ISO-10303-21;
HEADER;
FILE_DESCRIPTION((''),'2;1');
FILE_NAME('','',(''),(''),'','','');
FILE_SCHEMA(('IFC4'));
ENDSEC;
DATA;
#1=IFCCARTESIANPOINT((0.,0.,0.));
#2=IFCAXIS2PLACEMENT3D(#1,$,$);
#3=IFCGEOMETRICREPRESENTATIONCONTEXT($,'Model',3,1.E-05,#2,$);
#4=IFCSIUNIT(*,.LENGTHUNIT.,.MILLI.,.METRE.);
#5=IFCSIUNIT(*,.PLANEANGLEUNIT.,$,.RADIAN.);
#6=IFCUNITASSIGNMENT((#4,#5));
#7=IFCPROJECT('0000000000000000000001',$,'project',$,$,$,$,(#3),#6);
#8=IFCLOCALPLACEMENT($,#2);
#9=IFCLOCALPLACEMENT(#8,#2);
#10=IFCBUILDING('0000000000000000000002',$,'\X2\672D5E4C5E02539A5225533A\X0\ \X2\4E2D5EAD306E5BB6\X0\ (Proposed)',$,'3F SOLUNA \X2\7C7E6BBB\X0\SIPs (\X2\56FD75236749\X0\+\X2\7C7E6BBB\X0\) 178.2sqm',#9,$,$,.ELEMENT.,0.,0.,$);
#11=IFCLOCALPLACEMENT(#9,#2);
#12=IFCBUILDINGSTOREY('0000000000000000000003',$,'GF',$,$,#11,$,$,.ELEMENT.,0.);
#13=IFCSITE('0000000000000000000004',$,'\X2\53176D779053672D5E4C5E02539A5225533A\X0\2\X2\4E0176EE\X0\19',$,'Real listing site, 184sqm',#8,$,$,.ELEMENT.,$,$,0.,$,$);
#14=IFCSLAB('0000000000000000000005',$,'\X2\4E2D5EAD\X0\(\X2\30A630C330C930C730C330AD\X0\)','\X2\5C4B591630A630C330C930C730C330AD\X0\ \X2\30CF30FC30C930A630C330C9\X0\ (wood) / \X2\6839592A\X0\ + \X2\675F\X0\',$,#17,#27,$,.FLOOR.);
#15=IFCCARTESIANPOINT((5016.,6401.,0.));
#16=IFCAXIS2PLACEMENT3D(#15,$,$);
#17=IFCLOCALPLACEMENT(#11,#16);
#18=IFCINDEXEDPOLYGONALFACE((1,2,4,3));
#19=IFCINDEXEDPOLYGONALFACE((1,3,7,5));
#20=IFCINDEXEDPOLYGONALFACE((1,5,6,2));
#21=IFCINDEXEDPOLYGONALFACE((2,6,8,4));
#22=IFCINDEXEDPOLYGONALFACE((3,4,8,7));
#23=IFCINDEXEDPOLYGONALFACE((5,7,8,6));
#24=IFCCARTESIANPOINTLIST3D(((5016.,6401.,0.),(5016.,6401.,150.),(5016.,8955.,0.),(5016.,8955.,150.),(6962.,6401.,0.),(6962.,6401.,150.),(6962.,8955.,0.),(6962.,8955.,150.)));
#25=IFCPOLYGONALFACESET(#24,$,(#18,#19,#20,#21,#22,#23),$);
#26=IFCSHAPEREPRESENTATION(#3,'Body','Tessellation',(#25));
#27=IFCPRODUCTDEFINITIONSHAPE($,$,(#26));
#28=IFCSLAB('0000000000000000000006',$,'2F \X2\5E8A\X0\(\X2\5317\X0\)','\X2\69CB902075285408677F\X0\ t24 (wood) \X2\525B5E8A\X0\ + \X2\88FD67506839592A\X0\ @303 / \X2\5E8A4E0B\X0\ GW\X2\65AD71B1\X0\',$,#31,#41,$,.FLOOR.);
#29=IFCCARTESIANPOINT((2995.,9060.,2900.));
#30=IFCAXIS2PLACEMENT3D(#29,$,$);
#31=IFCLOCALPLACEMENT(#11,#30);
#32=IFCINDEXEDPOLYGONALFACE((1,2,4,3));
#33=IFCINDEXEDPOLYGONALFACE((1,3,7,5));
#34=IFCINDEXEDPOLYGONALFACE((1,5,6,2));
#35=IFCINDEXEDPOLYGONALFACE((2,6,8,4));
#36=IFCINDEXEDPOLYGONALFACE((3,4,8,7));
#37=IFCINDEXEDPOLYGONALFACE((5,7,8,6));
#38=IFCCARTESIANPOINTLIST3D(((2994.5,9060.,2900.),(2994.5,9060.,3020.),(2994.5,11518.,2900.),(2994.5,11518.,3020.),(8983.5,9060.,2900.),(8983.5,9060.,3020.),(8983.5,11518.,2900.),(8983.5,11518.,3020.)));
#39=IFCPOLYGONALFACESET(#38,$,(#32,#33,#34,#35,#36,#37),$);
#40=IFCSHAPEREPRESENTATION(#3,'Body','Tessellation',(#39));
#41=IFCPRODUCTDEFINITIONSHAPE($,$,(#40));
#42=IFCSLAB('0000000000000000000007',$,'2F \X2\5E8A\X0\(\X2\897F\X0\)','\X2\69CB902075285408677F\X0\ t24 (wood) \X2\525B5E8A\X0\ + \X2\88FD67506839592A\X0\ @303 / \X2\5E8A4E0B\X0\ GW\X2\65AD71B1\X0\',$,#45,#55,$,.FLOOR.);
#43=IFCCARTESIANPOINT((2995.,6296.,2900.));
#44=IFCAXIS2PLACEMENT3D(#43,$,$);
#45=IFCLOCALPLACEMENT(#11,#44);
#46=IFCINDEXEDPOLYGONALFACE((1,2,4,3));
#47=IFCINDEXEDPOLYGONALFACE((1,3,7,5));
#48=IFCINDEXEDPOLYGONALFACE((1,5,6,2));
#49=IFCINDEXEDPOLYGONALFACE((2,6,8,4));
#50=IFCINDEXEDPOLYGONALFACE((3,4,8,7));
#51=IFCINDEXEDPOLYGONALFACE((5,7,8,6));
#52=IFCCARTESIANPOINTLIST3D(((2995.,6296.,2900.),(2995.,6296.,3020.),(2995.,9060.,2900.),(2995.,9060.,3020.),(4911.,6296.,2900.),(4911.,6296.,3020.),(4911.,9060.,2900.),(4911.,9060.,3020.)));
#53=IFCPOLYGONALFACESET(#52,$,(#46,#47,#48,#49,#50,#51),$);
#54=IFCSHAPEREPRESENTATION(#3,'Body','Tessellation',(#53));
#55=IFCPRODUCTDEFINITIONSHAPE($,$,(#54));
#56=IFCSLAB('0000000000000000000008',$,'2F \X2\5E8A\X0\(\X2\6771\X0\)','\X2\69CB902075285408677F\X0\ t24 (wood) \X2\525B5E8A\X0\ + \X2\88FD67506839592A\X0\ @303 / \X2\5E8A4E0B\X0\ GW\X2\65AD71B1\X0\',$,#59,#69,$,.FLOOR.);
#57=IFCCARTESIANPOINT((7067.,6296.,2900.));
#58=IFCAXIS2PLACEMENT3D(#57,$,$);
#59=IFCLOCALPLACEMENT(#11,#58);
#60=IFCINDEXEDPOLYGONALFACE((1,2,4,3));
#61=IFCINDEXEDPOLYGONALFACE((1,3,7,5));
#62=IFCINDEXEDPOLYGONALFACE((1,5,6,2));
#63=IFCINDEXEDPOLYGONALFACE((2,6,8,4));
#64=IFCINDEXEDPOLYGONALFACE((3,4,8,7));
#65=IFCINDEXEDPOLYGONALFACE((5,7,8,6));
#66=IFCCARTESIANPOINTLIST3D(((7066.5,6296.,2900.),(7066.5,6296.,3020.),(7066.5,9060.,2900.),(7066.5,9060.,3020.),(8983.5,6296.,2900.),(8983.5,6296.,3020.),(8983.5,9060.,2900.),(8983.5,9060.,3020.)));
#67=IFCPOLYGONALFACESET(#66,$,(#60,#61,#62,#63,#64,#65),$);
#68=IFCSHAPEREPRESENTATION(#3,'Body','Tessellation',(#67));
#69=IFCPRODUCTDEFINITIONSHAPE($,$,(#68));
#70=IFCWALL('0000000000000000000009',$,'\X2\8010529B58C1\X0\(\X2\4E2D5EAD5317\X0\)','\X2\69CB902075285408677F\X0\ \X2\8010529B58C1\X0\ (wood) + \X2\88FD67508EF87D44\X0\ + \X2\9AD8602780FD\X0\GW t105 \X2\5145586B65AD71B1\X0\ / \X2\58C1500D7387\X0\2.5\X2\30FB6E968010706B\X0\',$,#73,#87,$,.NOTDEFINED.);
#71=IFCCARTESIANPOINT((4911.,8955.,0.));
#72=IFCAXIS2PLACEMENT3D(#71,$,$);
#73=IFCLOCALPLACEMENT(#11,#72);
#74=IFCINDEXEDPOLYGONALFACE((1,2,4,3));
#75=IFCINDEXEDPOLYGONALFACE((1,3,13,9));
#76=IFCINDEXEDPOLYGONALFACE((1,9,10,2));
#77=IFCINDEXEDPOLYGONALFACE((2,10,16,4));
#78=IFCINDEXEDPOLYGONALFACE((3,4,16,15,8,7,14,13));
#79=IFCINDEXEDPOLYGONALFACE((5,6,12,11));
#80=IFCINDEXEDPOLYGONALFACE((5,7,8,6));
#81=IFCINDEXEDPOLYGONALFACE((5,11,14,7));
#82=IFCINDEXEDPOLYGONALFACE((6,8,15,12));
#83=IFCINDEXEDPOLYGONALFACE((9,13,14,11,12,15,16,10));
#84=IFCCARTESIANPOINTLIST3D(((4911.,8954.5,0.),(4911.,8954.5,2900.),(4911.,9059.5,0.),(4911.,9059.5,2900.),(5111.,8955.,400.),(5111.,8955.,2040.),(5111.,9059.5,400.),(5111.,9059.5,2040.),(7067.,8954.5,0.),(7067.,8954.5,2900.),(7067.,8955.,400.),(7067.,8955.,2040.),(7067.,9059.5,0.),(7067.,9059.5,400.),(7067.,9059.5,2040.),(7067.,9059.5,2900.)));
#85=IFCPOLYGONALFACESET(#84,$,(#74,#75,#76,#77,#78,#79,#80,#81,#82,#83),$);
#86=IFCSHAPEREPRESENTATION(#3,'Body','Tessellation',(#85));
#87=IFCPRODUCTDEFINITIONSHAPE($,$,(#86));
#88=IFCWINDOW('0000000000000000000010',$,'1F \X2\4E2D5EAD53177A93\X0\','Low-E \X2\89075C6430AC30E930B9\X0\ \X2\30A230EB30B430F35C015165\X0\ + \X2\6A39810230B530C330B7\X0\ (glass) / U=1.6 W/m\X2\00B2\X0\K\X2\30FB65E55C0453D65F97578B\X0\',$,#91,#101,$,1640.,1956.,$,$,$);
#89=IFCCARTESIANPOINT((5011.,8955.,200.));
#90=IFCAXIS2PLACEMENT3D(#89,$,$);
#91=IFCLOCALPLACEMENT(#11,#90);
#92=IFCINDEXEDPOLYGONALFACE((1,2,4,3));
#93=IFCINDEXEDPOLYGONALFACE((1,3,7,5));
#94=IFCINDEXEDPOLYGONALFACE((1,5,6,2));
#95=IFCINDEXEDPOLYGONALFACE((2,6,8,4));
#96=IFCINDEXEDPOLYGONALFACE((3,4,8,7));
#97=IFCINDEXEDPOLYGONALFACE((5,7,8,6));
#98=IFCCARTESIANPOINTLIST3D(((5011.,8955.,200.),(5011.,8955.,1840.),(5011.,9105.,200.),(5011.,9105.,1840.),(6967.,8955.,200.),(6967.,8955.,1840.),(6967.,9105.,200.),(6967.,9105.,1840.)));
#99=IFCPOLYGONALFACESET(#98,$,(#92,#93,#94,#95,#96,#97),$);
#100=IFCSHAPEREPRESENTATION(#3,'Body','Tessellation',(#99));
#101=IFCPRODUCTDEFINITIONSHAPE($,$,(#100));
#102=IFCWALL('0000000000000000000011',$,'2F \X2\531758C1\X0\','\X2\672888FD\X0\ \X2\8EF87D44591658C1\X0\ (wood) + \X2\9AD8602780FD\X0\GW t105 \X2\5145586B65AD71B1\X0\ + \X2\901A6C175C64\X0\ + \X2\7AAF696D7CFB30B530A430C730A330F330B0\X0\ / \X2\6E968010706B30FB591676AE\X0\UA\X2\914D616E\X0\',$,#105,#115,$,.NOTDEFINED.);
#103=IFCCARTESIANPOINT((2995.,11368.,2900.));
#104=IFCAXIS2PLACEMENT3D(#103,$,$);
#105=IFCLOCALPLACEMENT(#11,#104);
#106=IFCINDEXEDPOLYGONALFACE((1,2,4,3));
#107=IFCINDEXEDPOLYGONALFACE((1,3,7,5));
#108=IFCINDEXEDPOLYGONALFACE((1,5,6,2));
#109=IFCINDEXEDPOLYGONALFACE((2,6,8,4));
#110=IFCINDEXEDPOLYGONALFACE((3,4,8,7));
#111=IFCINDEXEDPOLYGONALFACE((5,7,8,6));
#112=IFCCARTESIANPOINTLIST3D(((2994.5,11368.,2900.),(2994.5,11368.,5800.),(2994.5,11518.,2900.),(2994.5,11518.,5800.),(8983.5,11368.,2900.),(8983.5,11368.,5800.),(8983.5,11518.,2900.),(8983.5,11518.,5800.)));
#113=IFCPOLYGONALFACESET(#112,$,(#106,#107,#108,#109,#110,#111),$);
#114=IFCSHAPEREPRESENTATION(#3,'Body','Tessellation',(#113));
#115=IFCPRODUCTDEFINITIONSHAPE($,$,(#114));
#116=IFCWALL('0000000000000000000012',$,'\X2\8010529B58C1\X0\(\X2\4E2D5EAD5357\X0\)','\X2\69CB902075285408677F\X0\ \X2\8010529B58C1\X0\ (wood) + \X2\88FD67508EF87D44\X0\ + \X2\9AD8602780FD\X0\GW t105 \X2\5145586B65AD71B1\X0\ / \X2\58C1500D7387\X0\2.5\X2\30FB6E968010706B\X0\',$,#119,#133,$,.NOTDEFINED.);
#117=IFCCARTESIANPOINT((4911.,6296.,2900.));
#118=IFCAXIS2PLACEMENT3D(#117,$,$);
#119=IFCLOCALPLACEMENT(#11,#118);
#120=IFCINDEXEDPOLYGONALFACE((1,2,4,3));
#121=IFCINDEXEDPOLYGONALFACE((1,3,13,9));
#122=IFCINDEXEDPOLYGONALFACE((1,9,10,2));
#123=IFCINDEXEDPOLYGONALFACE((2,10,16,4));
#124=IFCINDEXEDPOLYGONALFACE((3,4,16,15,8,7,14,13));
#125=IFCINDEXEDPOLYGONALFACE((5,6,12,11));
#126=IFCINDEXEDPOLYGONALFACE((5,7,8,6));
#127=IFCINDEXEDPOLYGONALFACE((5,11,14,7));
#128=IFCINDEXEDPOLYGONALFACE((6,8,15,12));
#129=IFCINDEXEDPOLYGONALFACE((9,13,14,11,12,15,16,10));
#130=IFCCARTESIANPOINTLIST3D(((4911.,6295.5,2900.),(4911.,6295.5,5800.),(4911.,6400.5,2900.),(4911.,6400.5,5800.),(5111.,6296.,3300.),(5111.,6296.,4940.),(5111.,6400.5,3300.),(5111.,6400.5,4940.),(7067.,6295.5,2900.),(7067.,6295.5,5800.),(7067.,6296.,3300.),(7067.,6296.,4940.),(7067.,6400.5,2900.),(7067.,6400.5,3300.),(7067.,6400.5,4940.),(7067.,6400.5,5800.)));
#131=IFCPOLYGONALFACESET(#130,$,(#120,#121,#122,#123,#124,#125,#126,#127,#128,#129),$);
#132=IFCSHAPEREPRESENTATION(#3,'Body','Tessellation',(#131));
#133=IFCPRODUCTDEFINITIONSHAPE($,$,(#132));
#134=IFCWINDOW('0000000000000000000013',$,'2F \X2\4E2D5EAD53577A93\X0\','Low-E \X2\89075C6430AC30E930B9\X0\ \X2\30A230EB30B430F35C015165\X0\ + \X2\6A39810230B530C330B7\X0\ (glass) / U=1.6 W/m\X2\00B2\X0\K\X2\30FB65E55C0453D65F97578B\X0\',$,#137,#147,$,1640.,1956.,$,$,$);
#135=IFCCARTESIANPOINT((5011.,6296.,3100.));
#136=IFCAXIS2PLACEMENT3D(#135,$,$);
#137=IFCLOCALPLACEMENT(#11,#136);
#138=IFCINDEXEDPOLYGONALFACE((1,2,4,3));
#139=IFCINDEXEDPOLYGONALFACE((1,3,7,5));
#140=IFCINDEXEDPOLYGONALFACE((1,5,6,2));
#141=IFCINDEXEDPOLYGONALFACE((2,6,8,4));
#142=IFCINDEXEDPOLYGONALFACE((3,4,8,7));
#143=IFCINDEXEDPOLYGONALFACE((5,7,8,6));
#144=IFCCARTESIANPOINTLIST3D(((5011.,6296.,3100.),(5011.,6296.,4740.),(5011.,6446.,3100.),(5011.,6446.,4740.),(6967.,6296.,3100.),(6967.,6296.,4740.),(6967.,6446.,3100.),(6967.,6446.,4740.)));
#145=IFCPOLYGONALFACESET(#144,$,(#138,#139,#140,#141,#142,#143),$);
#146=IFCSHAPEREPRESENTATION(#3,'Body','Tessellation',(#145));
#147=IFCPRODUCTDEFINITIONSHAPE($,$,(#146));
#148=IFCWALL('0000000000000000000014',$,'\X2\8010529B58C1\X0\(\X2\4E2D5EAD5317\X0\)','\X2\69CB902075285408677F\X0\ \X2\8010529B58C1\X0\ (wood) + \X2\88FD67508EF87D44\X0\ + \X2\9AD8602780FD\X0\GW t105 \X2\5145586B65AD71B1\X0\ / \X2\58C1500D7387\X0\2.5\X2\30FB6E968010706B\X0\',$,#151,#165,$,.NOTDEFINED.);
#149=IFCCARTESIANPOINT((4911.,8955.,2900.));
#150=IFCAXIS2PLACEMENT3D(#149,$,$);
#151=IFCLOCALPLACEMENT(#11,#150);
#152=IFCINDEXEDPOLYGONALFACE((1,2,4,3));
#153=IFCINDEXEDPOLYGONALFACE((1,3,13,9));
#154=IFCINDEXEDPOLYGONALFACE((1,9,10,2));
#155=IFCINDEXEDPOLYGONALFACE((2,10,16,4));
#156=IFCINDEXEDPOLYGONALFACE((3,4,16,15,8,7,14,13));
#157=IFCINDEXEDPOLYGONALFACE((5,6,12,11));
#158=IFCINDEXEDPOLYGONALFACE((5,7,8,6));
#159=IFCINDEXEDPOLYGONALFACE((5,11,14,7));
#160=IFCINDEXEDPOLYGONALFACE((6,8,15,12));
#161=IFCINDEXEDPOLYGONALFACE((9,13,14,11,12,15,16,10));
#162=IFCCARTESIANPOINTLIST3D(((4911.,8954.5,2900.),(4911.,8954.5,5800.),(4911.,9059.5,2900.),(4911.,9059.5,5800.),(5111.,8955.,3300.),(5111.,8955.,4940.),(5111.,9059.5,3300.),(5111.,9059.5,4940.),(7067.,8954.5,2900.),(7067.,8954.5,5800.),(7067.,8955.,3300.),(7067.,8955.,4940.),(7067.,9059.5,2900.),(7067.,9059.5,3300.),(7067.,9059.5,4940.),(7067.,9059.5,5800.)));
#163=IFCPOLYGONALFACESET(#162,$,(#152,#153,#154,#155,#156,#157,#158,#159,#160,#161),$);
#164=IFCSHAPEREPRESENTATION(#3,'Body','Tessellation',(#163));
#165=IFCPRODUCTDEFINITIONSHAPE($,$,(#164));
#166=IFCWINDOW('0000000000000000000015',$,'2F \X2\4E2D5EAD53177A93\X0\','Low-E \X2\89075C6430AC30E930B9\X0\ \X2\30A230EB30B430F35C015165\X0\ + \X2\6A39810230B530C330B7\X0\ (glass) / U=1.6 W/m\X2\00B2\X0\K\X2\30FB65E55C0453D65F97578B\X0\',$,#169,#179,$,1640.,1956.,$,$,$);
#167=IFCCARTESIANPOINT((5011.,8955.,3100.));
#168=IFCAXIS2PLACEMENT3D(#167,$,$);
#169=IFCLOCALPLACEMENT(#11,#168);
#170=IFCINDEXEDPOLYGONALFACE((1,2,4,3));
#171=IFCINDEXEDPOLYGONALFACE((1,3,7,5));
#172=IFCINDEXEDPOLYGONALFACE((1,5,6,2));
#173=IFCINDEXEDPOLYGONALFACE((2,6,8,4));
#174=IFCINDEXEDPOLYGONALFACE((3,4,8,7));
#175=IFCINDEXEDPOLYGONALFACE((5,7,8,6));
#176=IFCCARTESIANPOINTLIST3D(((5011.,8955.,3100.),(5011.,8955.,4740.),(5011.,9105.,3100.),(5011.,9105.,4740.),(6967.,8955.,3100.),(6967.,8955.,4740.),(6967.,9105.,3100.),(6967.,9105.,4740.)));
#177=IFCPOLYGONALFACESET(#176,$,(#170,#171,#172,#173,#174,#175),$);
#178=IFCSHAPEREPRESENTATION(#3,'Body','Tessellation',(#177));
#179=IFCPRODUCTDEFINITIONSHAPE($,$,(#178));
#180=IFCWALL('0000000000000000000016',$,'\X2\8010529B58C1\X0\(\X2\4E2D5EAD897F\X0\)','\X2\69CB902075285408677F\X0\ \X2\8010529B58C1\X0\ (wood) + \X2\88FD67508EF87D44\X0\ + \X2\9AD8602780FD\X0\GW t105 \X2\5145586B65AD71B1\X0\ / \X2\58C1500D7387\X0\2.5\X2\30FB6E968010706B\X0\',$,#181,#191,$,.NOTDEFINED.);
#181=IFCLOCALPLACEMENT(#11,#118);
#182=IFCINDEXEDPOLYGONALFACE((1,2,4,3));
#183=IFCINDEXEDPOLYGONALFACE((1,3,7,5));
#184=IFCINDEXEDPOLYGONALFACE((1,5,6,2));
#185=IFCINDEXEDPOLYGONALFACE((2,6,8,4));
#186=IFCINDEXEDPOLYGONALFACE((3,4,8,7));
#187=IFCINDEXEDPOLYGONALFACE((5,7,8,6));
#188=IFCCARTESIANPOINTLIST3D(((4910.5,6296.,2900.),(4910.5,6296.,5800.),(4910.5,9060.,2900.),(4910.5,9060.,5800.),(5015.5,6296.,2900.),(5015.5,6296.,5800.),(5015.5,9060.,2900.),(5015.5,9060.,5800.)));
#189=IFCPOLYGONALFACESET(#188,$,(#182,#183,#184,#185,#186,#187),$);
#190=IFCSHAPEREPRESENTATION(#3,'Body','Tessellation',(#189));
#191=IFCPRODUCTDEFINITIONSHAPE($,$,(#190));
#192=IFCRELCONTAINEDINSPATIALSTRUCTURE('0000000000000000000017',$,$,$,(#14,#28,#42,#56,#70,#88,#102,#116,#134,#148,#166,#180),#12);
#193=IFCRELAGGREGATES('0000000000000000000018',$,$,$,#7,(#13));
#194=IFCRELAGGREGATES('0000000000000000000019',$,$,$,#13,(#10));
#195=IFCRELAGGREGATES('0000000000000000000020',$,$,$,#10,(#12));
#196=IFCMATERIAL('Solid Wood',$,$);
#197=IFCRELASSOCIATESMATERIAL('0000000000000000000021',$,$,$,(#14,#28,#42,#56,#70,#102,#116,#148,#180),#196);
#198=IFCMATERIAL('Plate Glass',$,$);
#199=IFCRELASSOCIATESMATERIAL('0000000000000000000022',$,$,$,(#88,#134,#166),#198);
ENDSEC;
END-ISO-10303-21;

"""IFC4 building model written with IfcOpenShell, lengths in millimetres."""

from ifc_helpers import new_model, si_unit, frame, frame_2d, origin, place, context, project, spatial, rectangle, extrude, material, element, fill, save


model = new_model("IFC4")

# Units and contexts
model_context = context("Model", 3, precision=1e-05, world=origin())
ifc_project = project(units=[si_unit("LENGTHUNIT", "METRE", prefix="MILLI"), si_unit("PLANEANGLEUNIT", "RADIAN")], contexts=[model_context])

# Site, building, storey
site_placement = place(None, origin())
site = spatial("IfcSite", under=ifc_project, at=site_placement, Name="北海道札幌市厚別区2丁目19", ObjectType="Real listing site, 184sqm", CompositionType="ELEMENT", RefElevation=0.0)
building_placement = place(site_placement, origin())
building = spatial("IfcBuilding", under=site, at=building_placement, Name="札幌市厚別区 中庭の家 (Proposed)", ObjectType="3F SOLUNA 籾殻SIPs (国産杉+籾殻) 178.2sqm", CompositionType="ELEMENT", ElevationOfRefHeight=0.0, ElevationOfTerrain=0.0)
storey_placement = place(building_placement, origin())
storey = spatial("IfcBuildingStorey", under=building, at=storey_placement, Name="GF", CompositionType="ELEMENT", Elevation=0.0)

# Slabs
ifc_material_1 = material(Name="Solid Wood")
slab_1_placement = place(storey_placement, frame((5016.0, 6401.0, 0.0)))
element("IfcSlab", 1, at=slab_1_placement, inside=storey, material=ifc_material_1, Name="中庭(ウッドデッキ)", Description="屋外ウッドデッキ ハードウッド (wood) / 根太 + 束", PredefinedType="FLOOR", context=model_context, shape_type="SweptSolid", body=[
    extrude(rectangle(XDim=1946.0, YDim=2554.0, at=frame_2d((973.0, 1277.0))), frame((5016.0, 6401.0, 0.0)), (0.0, 0.0, 1.0), 150.0),
])
slab_2_placement = place(storey_placement, frame((2995.0, 9060.0, 2900.0)))
element("IfcSlab", 2, at=slab_2_placement, inside=storey, material=ifc_material_1, Name="2F 床(北)", Description="構造用合板 t24 (wood) 剛床 + 製材根太 @303 / 床下 GW断熱", PredefinedType="FLOOR", context=model_context, shape_type="SweptSolid", body=[
    extrude(rectangle(XDim=5989.0, YDim=2458.0, at=frame_2d((2994.0, 1229.0))), frame((2995.0, 9060.0, 2900.0)), (0.0, 0.0, 1.0), 120.0),
])
slab_3_placement = place(storey_placement, frame((2995.0, 6296.0, 2900.0)))
element("IfcSlab", 3, at=slab_3_placement, inside=storey, material=ifc_material_1, Name="2F 床(西)", Description="構造用合板 t24 (wood) 剛床 + 製材根太 @303 / 床下 GW断熱", PredefinedType="FLOOR", context=model_context, shape_type="SweptSolid", body=[
    extrude(rectangle(XDim=1916.0, YDim=2764.0, at=frame_2d((958.0, 1382.0))), frame((2995.0, 6296.0, 2900.0)), (0.0, 0.0, 1.0), 120.0),
])
slab_4_placement = place(storey_placement, frame((7067.0, 6296.0, 2900.0)))
element("IfcSlab", 4, at=slab_4_placement, inside=storey, material=ifc_material_1, Name="2F 床(東)", Description="構造用合板 t24 (wood) 剛床 + 製材根太 @303 / 床下 GW断熱", PredefinedType="FLOOR", context=model_context, shape_type="SweptSolid", body=[
    extrude(rectangle(XDim=1917.0, YDim=2764.0, at=frame_2d((958.0, 1382.0))), frame((7067.0, 6296.0, 2900.0)), (0.0, 0.0, 1.0), 120.0),
])

# Wall, opening, window
wall_1_placement = place(storey_placement, frame((4911.0, 8955.0, 0.0)))
wall_1 = element("IfcWall", 5, at=wall_1_placement, inside=storey, material=ifc_material_1, Name="耐力壁(中庭北)", Description="構造用合板 耐力壁 (wood) + 製材軸組 + 高性能GW t105 充填断熱 / 壁倍率2.5・準耐火", PredefinedType="NOTDEFINED", context=model_context, shape_type="SweptSolid", body=[
    extrude(rectangle(XDim=2156.0, YDim=105.0, at=frame_2d((1078.0, 52.0))), frame((4911.0, 8955.0, 0.0)), (0.0, 0.0, 1.0), 2900.0),
])
opening_1_placement = place(storey_placement, frame((5011.0, 8955.0, 200.0)))
opening_1 = element("IfcOpeningElement", 6, at=opening_1_placement, cuts=wall_1, PredefinedType="NOTDEFINED", context=model_context, shape_type="SweptSolid", body=[
    extrude(rectangle(XDim=1956.0, YDim=150.0, at=frame_2d((978.0, 75.0))), frame((5011.0, 8955.0, 200.0)), (0.0, 0.0, 1.0), 1640.0),
])
ifc_material_2 = material(Name="Plate Glass")
window_1_placement = place(storey_placement, frame((5011.0, 8955.0, 200.0)))
window_1 = element("IfcWindow", 7, at=window_1_placement, inside=storey, material=ifc_material_2, Name="1F 中庭北窓", Description="Low-E 複層ガラス アルゴン封入 + 樹脂サッシ (glass) / U=1.6 W/m²K・日射取得型", OverallHeight=1640.0, OverallWidth=1956.0, context=model_context, shape_type="SweptSolid", body=[
    extrude(rectangle(XDim=1956.0, YDim=150.0, at=frame_2d((978.0, 75.0))), frame((5011.0, 8955.0, 200.0)), (0.0, 0.0, 1.0), 1640.0),
])
fill(opening_1, window_1)

# Wall
wall_2_placement = place(storey_placement, frame((2995.0, 11368.0, 2900.0)))
element("IfcWall", 8, at=wall_2_placement, inside=storey, material=ifc_material_1, Name="2F 北壁", Description="木製 軸組外壁 (wood) + 高性能GW t105 充填断熱 + 通気層 + 窯業系サイディング / 準耐火・外皮UA配慮", PredefinedType="NOTDEFINED", context=model_context, shape_type="SweptSolid", body=[
    extrude(rectangle(XDim=5989.0, YDim=150.0, at=frame_2d((2994.0, 75.0))), frame((2995.0, 11368.0, 2900.0)), (0.0, 0.0, 1.0), 2900.0),
])

# Walls, openings, windows
wall_3_placement = place(storey_placement, frame((4911.0, 6296.0, 2900.0)))
wall_3 = element("IfcWall", 9, at=wall_3_placement, inside=storey, material=ifc_material_1, Name="耐力壁(中庭南)", Description="構造用合板 耐力壁 (wood) + 製材軸組 + 高性能GW t105 充填断熱 / 壁倍率2.5・準耐火", PredefinedType="NOTDEFINED", context=model_context, shape_type="SweptSolid", body=[
    extrude(rectangle(XDim=2156.0, YDim=105.0, at=frame_2d((1078.0, 52.0))), frame((4911.0, 6296.0, 2900.0)), (0.0, 0.0, 1.0), 2900.0),
])
opening_2_placement = place(storey_placement, frame((5011.0, 6296.0, 3100.0)))
opening_2 = element("IfcOpeningElement", 10, at=opening_2_placement, cuts=wall_3, PredefinedType="NOTDEFINED", context=model_context, shape_type="SweptSolid", body=[
    extrude(rectangle(XDim=1956.0, YDim=150.0, at=frame_2d((978.0, 75.0))), frame((5011.0, 6296.0, 3100.0)), (0.0, 0.0, 1.0), 1640.0),
])
window_2_placement = place(storey_placement, frame((5011.0, 6296.0, 3100.0)))
window_2 = element("IfcWindow", 11, at=window_2_placement, inside=storey, material=ifc_material_2, Name="2F 中庭南窓", Description="Low-E 複層ガラス アルゴン封入 + 樹脂サッシ (glass) / U=1.6 W/m²K・日射取得型", OverallHeight=1640.0, OverallWidth=1956.0, context=model_context, shape_type="SweptSolid", body=[
    extrude(rectangle(XDim=1956.0, YDim=150.0, at=frame_2d((978.0, 75.0))), frame((5011.0, 6296.0, 3100.0)), (0.0, 0.0, 1.0), 1640.0),
])
fill(opening_2, window_2)
wall_4_placement = place(storey_placement, frame((4911.0, 8955.0, 2900.0)))
wall_4 = element("IfcWall", 12, at=wall_4_placement, inside=storey, material=ifc_material_1, Name="耐力壁(中庭北)", Description="構造用合板 耐力壁 (wood) + 製材軸組 + 高性能GW t105 充填断熱 / 壁倍率2.5・準耐火", PredefinedType="NOTDEFINED", context=model_context, shape_type="SweptSolid", body=[
    extrude(rectangle(XDim=2156.0, YDim=105.0, at=frame_2d((1078.0, 52.0))), frame((4911.0, 8955.0, 2900.0)), (0.0, 0.0, 1.0), 2900.0),
])
opening_3_placement = place(storey_placement, frame((5011.0, 8955.0, 3100.0)))
opening_3 = element("IfcOpeningElement", 13, at=opening_3_placement, cuts=wall_4, PredefinedType="NOTDEFINED", context=model_context, shape_type="SweptSolid", body=[
    extrude(rectangle(XDim=1956.0, YDim=150.0, at=frame_2d((978.0, 75.0))), frame((5011.0, 8955.0, 3100.0)), (0.0, 0.0, 1.0), 1640.0),
])
window_3_placement = place(storey_placement, frame((5011.0, 8955.0, 3100.0)))
window_3 = element("IfcWindow", 14, at=window_3_placement, inside=storey, material=ifc_material_2, Name="2F 中庭北窓", Description="Low-E 複層ガラス アルゴン封入 + 樹脂サッシ (glass) / U=1.6 W/m²K・日射取得型", OverallHeight=1640.0, OverallWidth=1956.0, context=model_context, shape_type="SweptSolid", body=[
    extrude(rectangle(XDim=1956.0, YDim=150.0, at=frame_2d((978.0, 75.0))), frame((5011.0, 8955.0, 3100.0)), (0.0, 0.0, 1.0), 1640.0),
])
fill(opening_3, window_3)

# Wall
wall_5_placement = place(storey_placement, frame((4911.0, 6296.0, 2900.0)))
element("IfcWall", 15, at=wall_5_placement, inside=storey, material=ifc_material_1, Name="耐力壁(中庭西)", Description="構造用合板 耐力壁 (wood) + 製材軸組 + 高性能GW t105 充填断熱 / 壁倍率2.5・準耐火", PredefinedType="NOTDEFINED", context=model_context, shape_type="SweptSolid", body=[
    extrude(rectangle(XDim=105.0, YDim=2764.0, at=frame_2d((52.0, 1382.0))), frame((4911.0, 6296.0, 2900.0)), (0.0, 0.0, 1.0), 2900.0),
])

save(model, "model.ifc")
